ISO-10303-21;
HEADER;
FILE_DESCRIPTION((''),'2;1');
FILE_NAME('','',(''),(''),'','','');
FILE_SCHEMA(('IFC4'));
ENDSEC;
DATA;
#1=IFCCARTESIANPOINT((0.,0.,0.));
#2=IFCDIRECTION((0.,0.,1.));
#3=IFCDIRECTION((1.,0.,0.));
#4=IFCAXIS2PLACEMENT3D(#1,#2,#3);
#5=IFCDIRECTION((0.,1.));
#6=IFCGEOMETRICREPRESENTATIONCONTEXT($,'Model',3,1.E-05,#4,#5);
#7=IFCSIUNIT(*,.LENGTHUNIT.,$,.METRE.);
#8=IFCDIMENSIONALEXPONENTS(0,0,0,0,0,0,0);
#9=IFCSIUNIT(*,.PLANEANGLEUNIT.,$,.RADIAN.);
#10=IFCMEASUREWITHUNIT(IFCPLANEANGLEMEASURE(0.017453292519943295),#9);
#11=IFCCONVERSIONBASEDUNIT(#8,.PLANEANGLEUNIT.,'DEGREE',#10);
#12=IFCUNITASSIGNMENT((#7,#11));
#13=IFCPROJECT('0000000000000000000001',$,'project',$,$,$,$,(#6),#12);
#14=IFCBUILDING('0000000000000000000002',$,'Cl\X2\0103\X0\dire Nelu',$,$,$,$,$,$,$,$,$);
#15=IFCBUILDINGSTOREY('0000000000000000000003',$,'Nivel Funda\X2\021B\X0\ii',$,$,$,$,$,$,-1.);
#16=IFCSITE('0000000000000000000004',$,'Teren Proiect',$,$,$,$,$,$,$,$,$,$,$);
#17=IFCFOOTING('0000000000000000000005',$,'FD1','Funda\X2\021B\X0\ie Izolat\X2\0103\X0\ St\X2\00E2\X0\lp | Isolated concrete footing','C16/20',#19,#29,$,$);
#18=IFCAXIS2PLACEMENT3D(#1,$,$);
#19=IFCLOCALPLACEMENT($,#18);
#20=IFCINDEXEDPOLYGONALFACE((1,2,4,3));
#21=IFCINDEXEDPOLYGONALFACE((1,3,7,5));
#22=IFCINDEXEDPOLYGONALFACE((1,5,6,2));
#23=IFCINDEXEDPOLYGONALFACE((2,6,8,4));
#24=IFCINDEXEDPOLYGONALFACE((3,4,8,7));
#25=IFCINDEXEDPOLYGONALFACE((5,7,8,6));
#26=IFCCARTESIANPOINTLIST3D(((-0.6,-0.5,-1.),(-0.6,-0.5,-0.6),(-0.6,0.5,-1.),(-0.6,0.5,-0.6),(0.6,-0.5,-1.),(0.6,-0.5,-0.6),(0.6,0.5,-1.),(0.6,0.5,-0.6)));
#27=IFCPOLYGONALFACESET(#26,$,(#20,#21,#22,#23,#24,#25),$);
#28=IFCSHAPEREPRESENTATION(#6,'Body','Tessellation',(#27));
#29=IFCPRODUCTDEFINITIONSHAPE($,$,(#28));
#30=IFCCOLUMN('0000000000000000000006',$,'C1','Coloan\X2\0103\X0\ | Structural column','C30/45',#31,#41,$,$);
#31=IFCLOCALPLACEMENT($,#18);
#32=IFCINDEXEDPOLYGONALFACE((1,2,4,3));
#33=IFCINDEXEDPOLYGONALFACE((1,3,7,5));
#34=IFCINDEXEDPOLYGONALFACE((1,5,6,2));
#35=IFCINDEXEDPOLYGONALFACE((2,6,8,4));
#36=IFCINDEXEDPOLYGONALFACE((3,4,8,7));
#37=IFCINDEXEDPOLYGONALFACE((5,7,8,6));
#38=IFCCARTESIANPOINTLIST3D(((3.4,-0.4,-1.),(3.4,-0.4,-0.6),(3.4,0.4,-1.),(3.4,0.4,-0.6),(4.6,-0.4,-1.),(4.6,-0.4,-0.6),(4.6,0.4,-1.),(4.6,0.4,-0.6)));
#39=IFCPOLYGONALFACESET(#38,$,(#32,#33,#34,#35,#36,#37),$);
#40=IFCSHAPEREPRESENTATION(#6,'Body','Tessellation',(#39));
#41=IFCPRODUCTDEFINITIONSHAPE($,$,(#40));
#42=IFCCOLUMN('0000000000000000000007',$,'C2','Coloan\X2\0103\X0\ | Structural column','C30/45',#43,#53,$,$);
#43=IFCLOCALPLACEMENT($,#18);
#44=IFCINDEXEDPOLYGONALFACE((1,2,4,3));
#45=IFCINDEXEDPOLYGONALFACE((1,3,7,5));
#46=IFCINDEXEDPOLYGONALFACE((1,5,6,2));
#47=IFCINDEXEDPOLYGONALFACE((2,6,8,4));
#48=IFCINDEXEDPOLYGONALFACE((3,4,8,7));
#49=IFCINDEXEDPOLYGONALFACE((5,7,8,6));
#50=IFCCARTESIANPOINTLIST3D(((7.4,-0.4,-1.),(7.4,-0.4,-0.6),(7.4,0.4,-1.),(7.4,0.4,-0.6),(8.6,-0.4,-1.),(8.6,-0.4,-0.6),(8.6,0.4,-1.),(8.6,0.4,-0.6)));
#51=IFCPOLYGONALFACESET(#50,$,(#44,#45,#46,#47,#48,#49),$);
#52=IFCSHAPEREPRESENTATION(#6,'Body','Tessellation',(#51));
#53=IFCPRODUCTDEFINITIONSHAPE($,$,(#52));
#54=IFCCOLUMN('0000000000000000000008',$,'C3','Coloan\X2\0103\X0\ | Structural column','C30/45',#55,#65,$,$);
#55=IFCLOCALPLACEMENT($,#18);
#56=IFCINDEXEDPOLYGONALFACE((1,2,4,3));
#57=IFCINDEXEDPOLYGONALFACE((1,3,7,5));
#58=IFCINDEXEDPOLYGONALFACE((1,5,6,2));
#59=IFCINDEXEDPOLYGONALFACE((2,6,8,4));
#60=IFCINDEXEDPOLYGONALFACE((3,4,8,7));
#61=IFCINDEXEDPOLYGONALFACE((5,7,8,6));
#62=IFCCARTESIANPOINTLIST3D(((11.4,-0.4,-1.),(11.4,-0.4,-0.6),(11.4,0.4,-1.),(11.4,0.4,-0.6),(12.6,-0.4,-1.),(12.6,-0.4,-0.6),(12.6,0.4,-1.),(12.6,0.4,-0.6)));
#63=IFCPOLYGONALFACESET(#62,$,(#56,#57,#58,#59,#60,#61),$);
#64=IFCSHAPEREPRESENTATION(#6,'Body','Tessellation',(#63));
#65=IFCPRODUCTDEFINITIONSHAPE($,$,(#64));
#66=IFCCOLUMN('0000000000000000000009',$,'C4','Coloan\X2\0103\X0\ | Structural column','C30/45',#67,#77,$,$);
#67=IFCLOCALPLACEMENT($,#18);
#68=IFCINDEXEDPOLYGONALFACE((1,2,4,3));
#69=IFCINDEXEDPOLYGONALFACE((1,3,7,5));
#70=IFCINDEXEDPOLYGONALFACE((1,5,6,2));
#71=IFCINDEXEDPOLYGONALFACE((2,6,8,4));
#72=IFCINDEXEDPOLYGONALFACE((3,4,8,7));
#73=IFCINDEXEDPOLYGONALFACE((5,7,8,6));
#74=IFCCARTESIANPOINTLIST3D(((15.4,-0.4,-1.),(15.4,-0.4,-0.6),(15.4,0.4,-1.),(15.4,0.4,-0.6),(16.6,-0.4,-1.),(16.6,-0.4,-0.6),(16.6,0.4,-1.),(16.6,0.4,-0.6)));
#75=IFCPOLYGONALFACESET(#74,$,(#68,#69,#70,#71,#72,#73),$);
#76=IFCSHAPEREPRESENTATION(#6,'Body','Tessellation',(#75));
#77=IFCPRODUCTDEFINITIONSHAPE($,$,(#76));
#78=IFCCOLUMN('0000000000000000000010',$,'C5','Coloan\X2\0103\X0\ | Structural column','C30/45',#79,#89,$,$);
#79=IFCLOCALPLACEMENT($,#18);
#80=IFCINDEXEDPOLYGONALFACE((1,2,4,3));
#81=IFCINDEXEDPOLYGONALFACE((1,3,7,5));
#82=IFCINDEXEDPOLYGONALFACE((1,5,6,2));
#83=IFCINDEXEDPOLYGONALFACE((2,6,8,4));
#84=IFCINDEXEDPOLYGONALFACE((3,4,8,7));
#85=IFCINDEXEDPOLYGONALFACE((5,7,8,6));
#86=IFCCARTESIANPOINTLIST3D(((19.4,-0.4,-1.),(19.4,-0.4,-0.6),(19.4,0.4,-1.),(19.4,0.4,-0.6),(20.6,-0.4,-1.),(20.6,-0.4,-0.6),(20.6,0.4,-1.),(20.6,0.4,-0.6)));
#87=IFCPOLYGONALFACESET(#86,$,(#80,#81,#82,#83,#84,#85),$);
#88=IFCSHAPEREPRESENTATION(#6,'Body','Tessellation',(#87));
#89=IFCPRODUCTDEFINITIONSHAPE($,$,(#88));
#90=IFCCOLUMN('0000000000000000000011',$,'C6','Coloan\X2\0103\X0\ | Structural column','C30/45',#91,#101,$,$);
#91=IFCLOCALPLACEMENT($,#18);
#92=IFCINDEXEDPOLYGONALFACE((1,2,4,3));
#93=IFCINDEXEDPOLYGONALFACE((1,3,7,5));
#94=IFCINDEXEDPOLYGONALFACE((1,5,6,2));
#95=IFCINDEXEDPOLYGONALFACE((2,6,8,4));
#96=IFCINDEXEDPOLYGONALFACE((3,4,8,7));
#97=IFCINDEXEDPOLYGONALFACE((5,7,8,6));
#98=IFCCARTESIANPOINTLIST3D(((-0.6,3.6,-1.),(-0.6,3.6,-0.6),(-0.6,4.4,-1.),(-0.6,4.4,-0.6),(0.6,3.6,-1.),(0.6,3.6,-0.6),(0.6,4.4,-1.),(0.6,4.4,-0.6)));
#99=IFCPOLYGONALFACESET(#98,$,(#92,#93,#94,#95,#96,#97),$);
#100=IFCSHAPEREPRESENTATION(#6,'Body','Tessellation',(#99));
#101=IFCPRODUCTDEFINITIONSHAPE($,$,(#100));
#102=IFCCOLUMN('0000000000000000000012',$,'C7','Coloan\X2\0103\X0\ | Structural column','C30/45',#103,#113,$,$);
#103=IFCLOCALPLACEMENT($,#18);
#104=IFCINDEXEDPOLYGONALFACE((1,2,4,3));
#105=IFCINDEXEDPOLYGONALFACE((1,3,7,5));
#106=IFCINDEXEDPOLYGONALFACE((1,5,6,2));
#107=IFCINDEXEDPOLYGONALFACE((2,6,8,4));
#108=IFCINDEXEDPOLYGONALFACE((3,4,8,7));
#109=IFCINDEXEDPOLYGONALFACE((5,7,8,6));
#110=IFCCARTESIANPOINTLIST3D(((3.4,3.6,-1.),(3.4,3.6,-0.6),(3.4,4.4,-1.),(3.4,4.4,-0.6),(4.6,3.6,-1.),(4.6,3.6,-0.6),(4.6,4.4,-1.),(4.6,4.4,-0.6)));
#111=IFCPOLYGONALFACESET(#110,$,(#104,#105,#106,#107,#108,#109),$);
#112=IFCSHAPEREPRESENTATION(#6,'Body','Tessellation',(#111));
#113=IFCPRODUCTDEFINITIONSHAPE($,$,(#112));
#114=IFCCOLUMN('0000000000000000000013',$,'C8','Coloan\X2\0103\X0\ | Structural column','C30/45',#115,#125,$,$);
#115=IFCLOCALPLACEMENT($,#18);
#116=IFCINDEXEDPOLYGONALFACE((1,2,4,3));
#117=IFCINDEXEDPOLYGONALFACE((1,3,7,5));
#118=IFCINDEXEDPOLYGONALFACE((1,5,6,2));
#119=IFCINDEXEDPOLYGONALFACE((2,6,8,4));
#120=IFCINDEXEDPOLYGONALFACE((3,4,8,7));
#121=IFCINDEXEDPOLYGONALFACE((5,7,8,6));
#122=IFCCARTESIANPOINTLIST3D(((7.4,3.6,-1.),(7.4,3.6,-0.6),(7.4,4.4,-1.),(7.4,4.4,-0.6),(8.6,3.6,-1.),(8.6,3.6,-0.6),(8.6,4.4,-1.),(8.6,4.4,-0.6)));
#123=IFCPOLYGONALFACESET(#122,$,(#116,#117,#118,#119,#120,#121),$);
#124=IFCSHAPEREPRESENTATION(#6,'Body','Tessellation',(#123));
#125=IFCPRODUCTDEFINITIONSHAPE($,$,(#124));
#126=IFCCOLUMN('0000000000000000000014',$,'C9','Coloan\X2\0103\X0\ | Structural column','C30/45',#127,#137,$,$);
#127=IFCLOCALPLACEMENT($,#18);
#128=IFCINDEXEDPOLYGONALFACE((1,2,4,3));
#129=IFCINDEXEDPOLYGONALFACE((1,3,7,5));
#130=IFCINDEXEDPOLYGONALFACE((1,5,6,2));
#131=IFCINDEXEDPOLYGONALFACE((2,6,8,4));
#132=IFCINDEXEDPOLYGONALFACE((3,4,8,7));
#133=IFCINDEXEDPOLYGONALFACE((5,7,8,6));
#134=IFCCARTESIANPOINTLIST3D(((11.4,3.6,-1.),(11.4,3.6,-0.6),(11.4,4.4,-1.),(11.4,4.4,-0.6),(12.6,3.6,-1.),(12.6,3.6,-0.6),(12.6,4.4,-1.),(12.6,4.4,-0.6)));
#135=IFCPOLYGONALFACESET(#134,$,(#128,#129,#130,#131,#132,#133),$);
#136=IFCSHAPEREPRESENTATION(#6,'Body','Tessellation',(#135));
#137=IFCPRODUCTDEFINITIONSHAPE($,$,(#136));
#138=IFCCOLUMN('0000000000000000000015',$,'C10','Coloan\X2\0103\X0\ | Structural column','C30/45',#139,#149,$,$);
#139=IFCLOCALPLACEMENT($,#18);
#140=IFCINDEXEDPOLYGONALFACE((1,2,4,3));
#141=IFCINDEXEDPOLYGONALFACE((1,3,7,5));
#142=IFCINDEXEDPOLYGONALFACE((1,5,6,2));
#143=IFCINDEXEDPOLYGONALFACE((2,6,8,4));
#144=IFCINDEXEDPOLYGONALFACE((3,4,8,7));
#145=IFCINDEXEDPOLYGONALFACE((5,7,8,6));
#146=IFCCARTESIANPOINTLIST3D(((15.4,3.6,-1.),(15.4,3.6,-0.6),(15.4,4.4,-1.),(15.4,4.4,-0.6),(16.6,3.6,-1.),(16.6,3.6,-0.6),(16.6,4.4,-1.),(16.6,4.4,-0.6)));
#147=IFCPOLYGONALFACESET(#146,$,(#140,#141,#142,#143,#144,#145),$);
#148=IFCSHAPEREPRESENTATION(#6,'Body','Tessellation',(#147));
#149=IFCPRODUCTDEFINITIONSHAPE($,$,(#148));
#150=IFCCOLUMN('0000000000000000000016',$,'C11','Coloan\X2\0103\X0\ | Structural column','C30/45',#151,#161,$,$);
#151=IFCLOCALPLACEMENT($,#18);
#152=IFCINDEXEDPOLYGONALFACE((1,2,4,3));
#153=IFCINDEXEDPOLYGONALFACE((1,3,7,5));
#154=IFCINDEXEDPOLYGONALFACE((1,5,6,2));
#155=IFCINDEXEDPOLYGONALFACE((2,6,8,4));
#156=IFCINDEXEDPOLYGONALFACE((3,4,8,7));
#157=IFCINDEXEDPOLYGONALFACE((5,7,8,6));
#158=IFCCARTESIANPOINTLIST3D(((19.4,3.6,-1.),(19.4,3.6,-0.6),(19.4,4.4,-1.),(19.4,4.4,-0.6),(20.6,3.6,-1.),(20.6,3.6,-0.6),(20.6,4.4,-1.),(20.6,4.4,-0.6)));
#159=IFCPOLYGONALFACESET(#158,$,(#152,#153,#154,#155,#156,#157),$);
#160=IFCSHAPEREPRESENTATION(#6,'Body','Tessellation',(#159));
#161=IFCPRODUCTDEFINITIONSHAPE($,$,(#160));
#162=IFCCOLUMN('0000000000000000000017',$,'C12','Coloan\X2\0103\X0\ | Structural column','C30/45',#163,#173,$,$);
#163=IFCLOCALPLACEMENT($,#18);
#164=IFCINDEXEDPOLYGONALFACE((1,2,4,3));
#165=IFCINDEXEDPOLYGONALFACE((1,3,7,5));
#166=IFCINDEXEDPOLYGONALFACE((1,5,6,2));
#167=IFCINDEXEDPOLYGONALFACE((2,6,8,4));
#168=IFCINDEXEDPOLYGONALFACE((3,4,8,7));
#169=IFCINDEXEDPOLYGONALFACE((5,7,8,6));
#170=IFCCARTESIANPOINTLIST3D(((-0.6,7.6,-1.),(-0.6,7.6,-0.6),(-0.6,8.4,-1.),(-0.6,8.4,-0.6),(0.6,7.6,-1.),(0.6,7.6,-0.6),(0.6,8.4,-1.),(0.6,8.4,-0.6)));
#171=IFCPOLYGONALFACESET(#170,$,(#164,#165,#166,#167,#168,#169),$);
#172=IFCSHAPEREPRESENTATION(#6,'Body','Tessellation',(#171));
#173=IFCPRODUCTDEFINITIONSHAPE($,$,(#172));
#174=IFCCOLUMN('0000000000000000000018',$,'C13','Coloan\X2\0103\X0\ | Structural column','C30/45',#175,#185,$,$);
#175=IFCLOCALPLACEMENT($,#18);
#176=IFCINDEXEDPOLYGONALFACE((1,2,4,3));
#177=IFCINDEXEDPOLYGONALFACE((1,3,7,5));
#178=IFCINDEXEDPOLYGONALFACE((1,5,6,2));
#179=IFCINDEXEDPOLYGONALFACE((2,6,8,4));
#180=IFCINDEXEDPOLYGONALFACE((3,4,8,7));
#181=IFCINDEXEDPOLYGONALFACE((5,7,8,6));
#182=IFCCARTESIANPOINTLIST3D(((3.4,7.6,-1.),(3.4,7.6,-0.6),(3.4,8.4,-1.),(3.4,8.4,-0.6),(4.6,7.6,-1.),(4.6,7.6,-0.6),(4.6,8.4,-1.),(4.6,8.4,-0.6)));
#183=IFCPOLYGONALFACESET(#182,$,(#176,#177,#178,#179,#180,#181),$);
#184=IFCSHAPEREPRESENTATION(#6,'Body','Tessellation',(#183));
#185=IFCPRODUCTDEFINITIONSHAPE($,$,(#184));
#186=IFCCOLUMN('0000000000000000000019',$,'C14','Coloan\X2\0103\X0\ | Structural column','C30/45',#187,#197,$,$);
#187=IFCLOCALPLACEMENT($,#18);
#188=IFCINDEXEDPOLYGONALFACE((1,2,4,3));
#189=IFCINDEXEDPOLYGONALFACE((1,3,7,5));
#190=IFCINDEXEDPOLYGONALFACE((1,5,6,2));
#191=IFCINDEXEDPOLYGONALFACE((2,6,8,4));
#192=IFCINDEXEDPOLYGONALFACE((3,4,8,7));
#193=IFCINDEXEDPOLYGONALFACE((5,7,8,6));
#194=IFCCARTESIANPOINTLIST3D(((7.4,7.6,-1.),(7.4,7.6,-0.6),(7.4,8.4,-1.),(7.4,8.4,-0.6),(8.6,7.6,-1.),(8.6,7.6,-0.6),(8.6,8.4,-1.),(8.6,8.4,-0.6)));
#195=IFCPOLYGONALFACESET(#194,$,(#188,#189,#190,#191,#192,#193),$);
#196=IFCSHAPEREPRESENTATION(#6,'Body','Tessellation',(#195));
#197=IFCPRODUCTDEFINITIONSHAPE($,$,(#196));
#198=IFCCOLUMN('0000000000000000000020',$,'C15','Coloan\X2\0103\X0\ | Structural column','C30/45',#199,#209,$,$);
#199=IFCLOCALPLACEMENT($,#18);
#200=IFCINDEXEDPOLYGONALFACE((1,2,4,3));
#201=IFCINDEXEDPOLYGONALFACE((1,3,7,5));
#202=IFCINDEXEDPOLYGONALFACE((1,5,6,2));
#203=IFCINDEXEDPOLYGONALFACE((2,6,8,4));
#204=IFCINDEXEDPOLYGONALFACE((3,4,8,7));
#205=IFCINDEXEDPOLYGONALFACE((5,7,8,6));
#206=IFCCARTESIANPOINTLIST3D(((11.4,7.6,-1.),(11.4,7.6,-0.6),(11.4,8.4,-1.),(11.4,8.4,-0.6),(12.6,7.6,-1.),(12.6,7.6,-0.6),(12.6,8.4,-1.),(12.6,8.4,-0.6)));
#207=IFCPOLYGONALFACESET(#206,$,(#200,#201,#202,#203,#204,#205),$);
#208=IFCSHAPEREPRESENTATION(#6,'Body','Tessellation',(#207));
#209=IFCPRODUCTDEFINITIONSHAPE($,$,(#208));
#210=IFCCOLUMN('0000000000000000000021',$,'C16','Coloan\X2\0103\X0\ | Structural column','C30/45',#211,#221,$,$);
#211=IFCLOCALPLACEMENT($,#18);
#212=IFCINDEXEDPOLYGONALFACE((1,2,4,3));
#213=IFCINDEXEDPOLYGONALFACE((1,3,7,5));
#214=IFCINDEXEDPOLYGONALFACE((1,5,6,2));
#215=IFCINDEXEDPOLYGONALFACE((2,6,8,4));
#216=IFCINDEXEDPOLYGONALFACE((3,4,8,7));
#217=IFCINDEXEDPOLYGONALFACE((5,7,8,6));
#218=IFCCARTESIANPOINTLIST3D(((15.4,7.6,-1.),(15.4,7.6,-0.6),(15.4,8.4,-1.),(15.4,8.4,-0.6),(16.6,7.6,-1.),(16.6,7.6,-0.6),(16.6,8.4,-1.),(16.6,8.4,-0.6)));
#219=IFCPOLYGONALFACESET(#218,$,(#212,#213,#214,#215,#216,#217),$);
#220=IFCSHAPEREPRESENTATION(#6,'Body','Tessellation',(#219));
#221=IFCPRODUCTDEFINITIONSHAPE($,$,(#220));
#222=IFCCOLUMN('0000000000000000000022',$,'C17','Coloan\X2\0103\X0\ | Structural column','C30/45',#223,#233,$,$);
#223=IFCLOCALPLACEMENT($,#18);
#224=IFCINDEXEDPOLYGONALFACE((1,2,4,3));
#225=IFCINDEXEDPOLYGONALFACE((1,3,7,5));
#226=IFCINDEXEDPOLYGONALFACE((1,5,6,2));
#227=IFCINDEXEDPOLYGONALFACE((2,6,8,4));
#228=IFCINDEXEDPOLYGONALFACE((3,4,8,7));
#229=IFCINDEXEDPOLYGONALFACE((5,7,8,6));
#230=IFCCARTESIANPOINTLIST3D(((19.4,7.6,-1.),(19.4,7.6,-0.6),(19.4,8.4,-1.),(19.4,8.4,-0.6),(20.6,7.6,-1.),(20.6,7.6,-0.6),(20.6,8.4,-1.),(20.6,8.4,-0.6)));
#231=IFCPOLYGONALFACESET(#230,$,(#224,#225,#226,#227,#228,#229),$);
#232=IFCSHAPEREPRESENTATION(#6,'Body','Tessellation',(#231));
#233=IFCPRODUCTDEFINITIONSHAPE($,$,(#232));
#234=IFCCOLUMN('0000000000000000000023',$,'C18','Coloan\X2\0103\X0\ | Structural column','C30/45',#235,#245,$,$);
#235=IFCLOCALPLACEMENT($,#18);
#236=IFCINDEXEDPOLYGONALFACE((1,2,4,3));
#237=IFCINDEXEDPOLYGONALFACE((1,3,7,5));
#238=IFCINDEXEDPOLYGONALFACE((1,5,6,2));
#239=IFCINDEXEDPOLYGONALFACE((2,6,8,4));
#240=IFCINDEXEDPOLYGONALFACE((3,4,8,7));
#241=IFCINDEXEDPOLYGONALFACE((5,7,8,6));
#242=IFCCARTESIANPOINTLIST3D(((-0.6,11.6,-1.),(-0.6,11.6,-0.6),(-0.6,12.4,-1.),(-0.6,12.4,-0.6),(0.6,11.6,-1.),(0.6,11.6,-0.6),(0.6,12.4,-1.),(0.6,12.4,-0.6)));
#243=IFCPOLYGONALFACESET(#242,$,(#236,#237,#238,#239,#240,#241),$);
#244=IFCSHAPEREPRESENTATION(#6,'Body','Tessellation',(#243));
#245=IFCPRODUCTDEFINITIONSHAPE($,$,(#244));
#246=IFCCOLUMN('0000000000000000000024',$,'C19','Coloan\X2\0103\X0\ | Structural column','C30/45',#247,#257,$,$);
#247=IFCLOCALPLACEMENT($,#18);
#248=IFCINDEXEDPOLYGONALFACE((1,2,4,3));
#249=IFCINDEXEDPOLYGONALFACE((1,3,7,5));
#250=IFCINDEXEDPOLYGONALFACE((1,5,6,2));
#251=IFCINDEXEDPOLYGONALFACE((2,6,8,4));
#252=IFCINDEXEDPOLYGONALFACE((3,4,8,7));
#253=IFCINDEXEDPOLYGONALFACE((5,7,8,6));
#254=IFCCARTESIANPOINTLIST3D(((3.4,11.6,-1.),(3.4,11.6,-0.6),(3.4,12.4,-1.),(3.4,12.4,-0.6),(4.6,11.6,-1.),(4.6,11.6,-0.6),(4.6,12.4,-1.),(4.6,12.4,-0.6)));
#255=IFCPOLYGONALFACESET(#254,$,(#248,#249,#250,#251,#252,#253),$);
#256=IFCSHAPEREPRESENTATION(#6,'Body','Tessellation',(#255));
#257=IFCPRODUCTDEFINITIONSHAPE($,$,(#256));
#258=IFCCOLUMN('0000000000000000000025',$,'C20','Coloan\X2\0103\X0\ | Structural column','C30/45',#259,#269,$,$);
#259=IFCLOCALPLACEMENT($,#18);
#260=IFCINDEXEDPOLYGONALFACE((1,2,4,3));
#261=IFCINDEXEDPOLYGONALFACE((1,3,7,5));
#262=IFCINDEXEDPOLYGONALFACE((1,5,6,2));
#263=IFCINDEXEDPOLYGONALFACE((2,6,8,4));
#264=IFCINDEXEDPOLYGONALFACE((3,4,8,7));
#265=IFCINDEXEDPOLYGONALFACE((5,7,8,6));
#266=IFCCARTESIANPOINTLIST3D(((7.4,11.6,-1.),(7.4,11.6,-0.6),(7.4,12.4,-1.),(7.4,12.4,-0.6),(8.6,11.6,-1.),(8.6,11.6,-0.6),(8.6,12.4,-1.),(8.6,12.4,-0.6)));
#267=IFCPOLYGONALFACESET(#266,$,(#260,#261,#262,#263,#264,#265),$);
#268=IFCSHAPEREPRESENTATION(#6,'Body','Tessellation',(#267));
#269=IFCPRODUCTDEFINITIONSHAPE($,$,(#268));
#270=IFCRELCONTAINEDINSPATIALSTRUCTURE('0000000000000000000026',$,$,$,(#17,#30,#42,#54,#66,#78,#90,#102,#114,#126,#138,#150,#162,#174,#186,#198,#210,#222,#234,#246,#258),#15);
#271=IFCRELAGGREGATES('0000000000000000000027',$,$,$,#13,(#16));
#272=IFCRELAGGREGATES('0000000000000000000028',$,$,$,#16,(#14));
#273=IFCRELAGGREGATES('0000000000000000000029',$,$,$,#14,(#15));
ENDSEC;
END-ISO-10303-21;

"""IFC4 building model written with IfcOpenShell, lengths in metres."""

from ifc_helpers import new_model, entity, si_unit, converted_unit, direction, frame, origin_with_axes, place, context, project, spatial, rectangle, extrude, element, save


model = new_model("IFC4")

# Units and contexts
model_context = context("Model", 3, precision=1e-05, world=origin_with_axes(), true_north=direction((0.0, 1.0)))
ifc_project = project(units=[si_unit("LENGTHUNIT", "METRE"), converted_unit("PLANEANGLEUNIT", "DEGREE", entity("IfcPlaneAngleMeasure", 0.017453292519943295), si_unit("PLANEANGLEUNIT", "RADIAN"), dimensions=[0, 0, 0, 0, 0, 0, 0])], contexts=[model_context])

# Site, building, storey
site = spatial("IfcSite", under=ifc_project, Name="Teren Proiect")
building = spatial("IfcBuilding", under=site, Name="Clădire Nelu")
storey = spatial("IfcBuildingStorey", under=building, Name="Nivel Fundații", Elevation=-1.0)

# Footing
footing_placement = place(None, frame((0.0, 0.0, -1.0), z_axis=(0.0, 0.0, 1.0), x_axis=(1.0, 0.0, 0.0)))
element("IfcFooting", 1, at=footing_placement, inside=storey, Name="FD1", Description="Fundație Izolată Stâlp | Isolated concrete footing", ObjectType="C16/20", context=model_context, shape_type="SweptSolid", body=[
    extrude(rectangle(XDim=1.2, YDim=1.0), None, (0.0, 0.0, 1.0), 0.4),
])

# Columns
for number, where, z_axis, x_axis, name in (
    (2, (4.0, 0.0, -1.0), (0.0, 0.0, 1.0), (1.0, 0.0, 0.0), "C1"),
    (3, (8.0, 0.0, -1.0), (0.0, 0.0, 1.0), (1.0, 0.0, 0.0), "C2"),
    (4, (12.0, 0.0, -1.0), (0.0, 0.0, 1.0), (1.0, 0.0, 0.0), "C3"),
    (5, (16.0, 0.0, -1.0), (0.0, 0.0, 1.0), (1.0, 0.0, 0.0), "C4"),
    (6, (20.0, 0.0, -1.0), (0.0, 0.0, 1.0), (1.0, 0.0, 0.0), "C5"),
    (7, (0.0, 4.0, -1.0), (0.0, 0.0, 1.0), (1.0, 0.0, 0.0), "C6"),
    (8, (4.0, 4.0, -1.0), (0.0, 0.0, 1.0), (1.0, 0.0, 0.0), "C7"),
    (9, (8.0, 4.0, -1.0), (0.0, 0.0, 1.0), (1.0, 0.0, 0.0), "C8"),
    (10, (12.0, 4.0, -1.0), (0.0, 0.0, 1.0), (1.0, 0.0, 0.0), "C9"),
    (11, (16.0, 4.0, -1.0), (0.0, 0.0, 1.0), (1.0, 0.0, 0.0), "C10"),
    (12, (20.0, 4.0, -1.0), (0.0, 0.0, 1.0), (1.0, 0.0, 0.0), "C11"),
    (13, (0.0, 8.0, -1.0), (0.0, 0.0, 1.0), (1.0, 0.0, 0.0), "C12"),
    (14, (4.0, 8.0, -1.0), (0.0, 0.0, 1.0), (1.0, 0.0, 0.0), "C13"),
    (15, (8.0, 8.0, -1.0), (0.0, 0.0, 1.0), (1.0, 0.0, 0.0), "C14"),
    (16, (12.0, 8.0, -1.0), (0.0, 0.0, 1.0), (1.0, 0.0, 0.0), "C15"),
    (17, (16.0, 8.0, -1.0), (0.0, 0.0, 1.0), (1.0, 0.0, 0.0), "C16"),
    (18, (20.0, 8.0, -1.0), (0.0, 0.0, 1.0), (1.0, 0.0, 0.0), "C17"),
    (19, (0.0, 12.0, -1.0), (0.0, 0.0, 1.0), (1.0, 0.0, 0.0), "C18"),
    (20, (4.0, 12.0, -1.0), (0.0, 0.0, 1.0), (1.0, 0.0, 0.0), "C19"),
    (21, (8.0, 12.0, -1.0), (0.0, 0.0, 1.0), (1.0, 0.0, 0.0), "C20"),
):
    element("IfcColumn", number, at=place(None, frame(where, z_axis=z_axis, x_axis=x_axis)), inside=storey, Name=name, Description="Coloană | Structural column", ObjectType="C30/45", context=model_context, shape_type="SweptSolid", body=[
        extrude(rectangle(XDim=1.2, YDim=0.8), None, (0.0, 0.0, 1.0), 0.4),
    ])

save(model, "model.ifc")
